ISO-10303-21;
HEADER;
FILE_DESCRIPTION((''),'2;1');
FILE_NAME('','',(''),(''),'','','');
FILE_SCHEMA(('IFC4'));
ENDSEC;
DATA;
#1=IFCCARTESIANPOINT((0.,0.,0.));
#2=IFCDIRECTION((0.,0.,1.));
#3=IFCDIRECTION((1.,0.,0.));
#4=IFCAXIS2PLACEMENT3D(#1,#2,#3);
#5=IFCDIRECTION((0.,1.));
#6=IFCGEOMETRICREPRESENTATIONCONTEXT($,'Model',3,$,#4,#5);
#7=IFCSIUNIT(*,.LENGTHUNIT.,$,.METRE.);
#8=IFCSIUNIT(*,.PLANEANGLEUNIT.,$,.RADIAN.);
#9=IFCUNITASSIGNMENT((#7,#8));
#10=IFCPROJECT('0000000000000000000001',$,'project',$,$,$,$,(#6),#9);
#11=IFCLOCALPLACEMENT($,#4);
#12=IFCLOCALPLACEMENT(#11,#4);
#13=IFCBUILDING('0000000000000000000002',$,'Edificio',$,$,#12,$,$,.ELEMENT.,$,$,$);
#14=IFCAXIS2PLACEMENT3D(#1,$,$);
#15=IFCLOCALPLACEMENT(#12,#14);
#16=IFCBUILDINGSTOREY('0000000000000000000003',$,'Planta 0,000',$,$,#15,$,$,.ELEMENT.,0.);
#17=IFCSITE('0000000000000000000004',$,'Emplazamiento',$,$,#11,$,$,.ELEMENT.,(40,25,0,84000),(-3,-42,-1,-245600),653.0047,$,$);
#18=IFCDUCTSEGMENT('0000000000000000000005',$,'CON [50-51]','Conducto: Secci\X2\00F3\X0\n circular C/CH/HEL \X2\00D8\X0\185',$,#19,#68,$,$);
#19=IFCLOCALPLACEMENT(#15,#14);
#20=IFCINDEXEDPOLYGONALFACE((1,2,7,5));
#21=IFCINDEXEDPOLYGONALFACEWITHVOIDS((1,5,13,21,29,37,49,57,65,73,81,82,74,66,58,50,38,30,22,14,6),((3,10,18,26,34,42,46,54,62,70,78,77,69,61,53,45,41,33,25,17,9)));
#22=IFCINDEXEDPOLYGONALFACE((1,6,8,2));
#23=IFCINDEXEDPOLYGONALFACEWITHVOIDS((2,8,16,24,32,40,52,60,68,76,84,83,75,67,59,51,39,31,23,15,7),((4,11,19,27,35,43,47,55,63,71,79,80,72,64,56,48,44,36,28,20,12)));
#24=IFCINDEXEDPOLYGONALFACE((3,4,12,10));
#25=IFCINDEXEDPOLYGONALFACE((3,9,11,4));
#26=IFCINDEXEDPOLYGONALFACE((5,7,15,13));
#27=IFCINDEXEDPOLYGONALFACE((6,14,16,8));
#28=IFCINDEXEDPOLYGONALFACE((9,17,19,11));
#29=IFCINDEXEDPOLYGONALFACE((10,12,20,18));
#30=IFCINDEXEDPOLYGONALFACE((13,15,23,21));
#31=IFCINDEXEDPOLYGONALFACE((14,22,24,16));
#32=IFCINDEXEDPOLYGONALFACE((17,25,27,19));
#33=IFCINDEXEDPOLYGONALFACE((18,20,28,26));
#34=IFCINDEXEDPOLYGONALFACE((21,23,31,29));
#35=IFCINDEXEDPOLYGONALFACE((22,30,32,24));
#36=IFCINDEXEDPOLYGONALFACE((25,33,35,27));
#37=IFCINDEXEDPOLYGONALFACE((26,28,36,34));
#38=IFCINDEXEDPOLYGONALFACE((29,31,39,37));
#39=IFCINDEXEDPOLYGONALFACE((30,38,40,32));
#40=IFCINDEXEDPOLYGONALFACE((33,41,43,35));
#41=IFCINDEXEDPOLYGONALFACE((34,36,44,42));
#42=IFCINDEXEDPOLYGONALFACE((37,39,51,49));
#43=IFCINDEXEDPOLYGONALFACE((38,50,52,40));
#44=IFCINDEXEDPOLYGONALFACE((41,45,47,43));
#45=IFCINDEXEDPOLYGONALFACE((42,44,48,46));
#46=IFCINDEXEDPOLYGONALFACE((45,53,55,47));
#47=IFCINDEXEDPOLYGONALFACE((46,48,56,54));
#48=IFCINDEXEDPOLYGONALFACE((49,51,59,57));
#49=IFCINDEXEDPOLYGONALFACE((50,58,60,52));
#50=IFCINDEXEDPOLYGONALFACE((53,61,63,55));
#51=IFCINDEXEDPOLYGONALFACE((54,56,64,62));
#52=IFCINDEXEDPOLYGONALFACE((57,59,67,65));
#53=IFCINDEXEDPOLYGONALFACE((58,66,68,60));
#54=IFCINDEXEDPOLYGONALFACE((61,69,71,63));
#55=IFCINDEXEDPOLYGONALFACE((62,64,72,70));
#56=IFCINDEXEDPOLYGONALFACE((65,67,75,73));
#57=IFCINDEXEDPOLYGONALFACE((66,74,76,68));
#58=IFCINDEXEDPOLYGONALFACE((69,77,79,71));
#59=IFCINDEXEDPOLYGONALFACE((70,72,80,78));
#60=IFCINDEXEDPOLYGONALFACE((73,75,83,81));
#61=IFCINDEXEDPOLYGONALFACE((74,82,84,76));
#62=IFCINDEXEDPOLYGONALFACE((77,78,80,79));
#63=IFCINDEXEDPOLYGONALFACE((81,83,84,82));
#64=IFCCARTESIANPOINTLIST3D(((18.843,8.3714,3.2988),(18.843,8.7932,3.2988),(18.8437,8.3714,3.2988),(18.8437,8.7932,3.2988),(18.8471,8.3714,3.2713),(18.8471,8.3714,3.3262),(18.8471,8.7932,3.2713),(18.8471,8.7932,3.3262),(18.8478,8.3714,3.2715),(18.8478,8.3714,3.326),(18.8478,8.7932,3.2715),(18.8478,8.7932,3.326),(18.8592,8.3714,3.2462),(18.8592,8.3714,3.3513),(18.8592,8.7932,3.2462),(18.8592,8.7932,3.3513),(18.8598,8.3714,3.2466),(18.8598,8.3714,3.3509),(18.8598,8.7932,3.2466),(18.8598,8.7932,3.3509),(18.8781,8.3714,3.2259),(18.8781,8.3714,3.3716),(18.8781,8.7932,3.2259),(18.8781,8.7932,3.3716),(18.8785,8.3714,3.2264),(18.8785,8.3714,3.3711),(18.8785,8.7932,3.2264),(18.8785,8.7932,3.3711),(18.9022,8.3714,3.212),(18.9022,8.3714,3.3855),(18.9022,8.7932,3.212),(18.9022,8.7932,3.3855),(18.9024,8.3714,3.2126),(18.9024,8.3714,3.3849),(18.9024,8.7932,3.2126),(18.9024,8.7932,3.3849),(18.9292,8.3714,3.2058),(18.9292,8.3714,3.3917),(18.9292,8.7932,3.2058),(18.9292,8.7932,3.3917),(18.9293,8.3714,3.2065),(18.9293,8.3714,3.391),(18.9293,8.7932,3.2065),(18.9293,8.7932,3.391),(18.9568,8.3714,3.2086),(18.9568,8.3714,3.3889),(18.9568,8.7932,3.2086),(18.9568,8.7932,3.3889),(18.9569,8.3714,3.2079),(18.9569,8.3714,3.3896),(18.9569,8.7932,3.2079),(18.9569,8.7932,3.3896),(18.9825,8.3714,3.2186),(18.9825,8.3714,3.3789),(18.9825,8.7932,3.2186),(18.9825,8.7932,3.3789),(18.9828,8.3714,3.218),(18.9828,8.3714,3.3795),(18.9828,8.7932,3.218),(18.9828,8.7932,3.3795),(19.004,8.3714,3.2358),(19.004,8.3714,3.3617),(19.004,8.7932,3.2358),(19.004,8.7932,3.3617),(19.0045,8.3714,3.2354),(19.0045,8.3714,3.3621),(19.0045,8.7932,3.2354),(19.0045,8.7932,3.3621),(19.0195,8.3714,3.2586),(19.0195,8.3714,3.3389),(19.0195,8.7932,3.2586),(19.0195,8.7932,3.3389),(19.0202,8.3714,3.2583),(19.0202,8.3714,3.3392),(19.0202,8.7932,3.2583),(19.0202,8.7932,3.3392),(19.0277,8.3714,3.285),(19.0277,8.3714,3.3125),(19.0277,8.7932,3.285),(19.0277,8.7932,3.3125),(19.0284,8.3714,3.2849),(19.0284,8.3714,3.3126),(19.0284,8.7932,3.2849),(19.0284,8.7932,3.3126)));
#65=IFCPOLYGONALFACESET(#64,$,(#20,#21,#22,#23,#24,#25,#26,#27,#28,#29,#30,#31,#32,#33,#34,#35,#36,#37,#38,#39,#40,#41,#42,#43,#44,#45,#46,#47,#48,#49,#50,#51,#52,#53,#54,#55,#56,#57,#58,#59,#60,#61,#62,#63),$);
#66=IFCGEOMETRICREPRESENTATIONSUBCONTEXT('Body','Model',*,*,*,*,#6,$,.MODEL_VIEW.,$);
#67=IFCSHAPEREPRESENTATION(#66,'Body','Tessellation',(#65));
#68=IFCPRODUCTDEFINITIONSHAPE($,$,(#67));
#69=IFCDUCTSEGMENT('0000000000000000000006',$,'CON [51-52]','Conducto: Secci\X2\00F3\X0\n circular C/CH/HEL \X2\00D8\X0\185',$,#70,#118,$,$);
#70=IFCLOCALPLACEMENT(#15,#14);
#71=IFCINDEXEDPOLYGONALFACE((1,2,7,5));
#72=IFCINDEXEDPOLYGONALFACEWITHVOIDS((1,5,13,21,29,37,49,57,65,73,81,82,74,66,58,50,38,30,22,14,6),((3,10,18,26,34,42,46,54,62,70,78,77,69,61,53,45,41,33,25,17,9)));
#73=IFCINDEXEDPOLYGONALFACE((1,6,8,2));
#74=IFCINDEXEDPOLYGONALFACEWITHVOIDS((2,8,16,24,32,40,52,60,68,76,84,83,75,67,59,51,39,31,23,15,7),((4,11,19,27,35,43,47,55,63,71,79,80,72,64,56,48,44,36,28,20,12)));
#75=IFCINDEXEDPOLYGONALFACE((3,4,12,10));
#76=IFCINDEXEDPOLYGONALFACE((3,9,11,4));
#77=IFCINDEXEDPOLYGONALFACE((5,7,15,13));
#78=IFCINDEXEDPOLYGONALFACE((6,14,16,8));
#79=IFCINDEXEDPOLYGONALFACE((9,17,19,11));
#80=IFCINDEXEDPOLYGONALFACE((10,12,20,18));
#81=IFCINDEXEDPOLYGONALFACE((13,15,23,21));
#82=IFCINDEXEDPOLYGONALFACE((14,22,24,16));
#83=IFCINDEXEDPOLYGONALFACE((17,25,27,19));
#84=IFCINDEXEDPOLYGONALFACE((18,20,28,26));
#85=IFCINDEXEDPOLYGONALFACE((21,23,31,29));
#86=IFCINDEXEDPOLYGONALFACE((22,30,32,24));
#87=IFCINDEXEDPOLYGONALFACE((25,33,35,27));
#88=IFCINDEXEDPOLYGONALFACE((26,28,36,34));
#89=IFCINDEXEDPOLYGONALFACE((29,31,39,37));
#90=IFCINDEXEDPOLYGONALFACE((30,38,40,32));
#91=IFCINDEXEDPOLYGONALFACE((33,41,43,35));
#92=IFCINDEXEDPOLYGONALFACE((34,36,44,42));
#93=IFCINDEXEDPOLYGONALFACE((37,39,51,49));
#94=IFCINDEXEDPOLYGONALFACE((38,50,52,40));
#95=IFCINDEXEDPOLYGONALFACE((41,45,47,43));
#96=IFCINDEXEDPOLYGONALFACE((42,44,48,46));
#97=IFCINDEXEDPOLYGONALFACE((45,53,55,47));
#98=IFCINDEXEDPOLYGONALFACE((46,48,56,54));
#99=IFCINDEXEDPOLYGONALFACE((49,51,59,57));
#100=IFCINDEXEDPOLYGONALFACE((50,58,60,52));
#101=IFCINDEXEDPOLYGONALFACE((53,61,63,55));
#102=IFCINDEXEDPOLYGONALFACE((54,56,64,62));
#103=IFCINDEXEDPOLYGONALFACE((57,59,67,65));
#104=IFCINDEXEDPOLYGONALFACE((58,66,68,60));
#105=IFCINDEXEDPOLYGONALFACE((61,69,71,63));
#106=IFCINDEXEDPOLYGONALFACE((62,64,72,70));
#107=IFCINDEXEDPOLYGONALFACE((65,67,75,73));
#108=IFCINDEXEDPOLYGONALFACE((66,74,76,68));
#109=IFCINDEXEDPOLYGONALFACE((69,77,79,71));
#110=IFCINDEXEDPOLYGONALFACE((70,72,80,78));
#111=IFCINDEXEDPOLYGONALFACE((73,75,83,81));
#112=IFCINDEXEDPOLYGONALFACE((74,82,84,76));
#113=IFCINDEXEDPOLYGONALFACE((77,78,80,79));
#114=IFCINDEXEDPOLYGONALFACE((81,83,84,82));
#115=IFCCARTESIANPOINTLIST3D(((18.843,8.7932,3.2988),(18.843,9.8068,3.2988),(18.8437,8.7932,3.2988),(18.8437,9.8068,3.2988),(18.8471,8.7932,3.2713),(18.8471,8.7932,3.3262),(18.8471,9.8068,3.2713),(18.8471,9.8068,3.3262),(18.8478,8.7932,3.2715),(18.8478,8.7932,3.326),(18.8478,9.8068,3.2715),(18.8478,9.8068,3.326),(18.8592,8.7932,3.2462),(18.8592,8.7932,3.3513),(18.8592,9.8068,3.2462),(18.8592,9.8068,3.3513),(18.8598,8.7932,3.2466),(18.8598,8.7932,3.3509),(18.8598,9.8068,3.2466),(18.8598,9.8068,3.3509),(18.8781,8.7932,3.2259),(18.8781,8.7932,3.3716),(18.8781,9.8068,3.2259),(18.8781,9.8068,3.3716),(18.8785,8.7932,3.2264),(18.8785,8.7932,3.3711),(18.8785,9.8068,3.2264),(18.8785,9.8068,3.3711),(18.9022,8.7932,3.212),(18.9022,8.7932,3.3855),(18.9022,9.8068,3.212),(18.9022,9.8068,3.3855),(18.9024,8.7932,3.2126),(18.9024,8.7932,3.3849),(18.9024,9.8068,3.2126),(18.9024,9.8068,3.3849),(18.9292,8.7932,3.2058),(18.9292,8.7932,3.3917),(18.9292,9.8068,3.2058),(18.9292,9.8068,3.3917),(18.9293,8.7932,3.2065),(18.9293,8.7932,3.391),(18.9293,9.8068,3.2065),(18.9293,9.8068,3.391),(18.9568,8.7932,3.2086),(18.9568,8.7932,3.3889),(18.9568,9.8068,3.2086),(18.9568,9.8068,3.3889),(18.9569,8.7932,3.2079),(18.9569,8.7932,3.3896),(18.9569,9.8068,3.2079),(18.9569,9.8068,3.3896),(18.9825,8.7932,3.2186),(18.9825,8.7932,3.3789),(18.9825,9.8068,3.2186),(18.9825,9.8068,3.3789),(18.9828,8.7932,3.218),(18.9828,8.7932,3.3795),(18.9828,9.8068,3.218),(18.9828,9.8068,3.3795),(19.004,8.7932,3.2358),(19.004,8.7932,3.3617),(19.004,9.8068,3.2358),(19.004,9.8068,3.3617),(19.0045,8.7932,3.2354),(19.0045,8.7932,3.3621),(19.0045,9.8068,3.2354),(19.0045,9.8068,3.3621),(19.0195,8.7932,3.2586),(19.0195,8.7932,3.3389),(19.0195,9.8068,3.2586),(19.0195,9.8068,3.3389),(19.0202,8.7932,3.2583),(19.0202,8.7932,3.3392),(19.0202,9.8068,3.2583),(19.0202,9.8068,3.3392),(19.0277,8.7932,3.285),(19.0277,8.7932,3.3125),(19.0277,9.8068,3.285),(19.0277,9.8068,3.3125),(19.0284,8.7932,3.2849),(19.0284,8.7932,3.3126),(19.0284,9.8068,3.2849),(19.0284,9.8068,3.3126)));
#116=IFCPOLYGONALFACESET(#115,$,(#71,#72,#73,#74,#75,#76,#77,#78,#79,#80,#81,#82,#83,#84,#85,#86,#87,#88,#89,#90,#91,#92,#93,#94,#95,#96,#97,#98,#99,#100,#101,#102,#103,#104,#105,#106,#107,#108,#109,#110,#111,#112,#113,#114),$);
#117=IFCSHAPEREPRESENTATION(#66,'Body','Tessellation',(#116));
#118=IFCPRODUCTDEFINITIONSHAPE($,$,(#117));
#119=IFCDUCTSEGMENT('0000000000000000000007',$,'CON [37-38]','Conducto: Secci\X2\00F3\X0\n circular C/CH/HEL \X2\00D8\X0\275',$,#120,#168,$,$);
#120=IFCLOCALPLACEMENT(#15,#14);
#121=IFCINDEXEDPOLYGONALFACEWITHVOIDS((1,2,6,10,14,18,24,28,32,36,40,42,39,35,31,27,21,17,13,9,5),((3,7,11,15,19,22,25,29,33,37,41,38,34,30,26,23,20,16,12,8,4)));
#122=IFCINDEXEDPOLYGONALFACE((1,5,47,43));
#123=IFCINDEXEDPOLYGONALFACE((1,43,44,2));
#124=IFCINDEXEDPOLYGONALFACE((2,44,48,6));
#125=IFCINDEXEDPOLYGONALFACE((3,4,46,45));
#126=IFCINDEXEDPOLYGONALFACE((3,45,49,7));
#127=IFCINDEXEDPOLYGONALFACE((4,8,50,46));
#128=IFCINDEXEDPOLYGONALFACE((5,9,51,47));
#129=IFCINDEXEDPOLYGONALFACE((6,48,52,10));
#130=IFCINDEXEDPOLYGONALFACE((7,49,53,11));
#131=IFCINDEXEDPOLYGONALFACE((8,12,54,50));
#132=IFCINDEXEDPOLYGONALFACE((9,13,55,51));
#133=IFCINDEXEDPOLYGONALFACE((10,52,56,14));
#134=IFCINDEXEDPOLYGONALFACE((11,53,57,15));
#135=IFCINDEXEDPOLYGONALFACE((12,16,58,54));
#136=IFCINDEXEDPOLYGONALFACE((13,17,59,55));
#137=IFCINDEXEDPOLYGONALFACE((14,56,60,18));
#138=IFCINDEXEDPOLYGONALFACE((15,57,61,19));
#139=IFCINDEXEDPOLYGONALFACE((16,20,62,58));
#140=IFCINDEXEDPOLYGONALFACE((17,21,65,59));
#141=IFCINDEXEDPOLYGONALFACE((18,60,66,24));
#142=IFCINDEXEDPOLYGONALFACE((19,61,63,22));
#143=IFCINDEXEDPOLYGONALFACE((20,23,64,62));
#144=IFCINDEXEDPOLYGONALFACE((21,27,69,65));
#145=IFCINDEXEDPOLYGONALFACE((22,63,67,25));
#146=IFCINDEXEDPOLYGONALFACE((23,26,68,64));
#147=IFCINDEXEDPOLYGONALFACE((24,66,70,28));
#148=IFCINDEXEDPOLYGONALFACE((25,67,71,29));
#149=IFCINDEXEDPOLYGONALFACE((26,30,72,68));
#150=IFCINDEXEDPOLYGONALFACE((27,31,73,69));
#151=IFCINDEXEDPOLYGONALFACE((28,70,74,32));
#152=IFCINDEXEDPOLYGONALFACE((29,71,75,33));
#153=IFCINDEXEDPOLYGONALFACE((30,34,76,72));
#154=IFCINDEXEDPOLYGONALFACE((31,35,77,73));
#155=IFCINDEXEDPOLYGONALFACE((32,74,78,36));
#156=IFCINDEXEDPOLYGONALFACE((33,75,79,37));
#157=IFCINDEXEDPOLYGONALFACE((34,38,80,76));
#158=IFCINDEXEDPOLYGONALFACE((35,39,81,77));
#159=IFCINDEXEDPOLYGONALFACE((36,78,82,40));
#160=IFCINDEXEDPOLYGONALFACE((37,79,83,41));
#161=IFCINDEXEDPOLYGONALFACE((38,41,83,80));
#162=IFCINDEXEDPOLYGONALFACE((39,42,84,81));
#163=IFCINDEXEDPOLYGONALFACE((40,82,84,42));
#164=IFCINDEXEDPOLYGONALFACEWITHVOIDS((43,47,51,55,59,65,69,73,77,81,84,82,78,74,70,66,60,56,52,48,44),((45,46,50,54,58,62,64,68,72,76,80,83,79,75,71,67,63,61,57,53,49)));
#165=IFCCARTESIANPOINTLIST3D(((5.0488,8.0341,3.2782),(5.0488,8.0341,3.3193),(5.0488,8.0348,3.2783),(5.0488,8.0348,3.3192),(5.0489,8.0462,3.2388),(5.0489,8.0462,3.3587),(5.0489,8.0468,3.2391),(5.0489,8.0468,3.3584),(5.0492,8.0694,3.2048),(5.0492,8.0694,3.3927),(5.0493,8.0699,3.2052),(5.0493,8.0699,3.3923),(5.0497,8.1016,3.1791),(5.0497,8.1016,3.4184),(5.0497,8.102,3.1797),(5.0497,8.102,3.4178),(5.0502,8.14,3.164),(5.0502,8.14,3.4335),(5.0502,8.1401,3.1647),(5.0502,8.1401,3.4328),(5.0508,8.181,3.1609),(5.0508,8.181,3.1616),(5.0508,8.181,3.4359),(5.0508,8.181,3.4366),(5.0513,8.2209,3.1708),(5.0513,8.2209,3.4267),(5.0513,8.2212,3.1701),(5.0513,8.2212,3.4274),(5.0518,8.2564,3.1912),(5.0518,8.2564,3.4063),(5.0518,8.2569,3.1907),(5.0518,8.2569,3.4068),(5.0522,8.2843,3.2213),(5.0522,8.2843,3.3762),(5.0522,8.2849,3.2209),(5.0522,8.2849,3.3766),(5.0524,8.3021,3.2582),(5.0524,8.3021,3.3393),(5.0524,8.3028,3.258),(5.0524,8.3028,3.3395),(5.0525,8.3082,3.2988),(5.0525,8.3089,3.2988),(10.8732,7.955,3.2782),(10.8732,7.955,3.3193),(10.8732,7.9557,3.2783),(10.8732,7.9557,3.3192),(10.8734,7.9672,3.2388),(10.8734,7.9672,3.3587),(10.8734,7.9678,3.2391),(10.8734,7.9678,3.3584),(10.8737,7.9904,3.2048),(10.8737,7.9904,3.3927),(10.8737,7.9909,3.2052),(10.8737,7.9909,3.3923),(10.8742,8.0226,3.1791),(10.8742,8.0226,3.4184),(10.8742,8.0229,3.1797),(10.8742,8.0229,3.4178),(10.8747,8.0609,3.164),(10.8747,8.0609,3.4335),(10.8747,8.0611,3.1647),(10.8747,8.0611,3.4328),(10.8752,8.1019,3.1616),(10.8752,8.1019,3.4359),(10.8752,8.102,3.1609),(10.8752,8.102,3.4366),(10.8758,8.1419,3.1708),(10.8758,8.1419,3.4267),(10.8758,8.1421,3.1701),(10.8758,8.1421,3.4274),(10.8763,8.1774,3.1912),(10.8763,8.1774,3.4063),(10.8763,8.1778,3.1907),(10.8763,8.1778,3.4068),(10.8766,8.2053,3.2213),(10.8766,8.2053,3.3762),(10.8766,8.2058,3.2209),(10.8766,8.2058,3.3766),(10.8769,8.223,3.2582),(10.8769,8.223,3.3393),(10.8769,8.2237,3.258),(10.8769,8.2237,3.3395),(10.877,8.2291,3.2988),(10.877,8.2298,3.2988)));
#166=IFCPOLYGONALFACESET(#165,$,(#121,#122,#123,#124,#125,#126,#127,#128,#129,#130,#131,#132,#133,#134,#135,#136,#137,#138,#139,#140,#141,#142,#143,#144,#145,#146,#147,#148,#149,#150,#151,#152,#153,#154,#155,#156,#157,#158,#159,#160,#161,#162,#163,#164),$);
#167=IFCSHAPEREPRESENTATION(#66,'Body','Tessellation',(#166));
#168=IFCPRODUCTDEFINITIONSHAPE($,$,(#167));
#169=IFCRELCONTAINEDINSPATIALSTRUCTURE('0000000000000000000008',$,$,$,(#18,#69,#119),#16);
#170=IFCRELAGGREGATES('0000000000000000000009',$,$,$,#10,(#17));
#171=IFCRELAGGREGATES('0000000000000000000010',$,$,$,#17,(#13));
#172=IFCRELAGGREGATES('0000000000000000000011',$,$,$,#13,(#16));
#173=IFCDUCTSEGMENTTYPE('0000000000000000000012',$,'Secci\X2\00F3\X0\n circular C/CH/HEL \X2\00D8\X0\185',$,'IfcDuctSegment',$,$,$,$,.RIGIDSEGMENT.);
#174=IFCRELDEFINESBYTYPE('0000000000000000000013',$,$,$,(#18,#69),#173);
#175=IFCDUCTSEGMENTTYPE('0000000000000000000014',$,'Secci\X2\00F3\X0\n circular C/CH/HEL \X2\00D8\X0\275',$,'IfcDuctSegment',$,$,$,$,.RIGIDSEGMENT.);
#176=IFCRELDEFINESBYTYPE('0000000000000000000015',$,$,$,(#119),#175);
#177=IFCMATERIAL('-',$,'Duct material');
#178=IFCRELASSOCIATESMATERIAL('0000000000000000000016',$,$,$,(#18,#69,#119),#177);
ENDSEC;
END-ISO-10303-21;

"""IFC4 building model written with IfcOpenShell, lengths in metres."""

from ifc_helpers import new_model, si_unit, direction, frame, origin, origin_with_axes, origin_2d_with_axis, place, context, subcontext, project, spatial, hollow_circle, extrude, material, type_object, element, save


model = new_model("IFC4")

# Units and contexts
model_context = context("Model", 3, world=origin_with_axes(), true_north=direction((0.0, 1.0)))
body_context = subcontext(model_context, "Body", "Model", "MODEL_VIEW")
ifc_project = project(units=[si_unit("LENGTHUNIT", "METRE"), si_unit("PLANEANGLEUNIT", "RADIAN")], contexts=[model_context])

# Site, building, storey
site_placement = place(None, origin_with_axes())
site = spatial("IfcSite", under=ifc_project, at=site_placement, Name="Emplazamiento", CompositionType="ELEMENT", RefLatitude=(40, 25, 0, 84000), RefLongitude=(-3, -42, -1, -245600), RefElevation=653.0047)
building_placement = place(site_placement, origin_with_axes())
building = spatial("IfcBuilding", under=site, at=building_placement, Name="Edificio", CompositionType="ELEMENT")
storey_placement = place(building_placement, origin())
storey = spatial("IfcBuildingStorey", under=building, at=storey_placement, Name="Planta 0,000", CompositionType="ELEMENT", Elevation=0.0)

# Shared definitions
ifc_material_1 = material(Name="-", Category="Duct material")

# Duct segments
duct_segment_type_1 = type_object("IfcDuctSegmentType", Name="Sección circular C/CH/HEL Ø185", ApplicableOccurrence="IfcDuctSegment", PredefinedType="RIGIDSEGMENT")
duct_segment_1_placement = place(storey_placement, origin_with_axes())
element("IfcDuctSegment", 1, at=duct_segment_1_placement, inside=storey, type_object=duct_segment_type_1, material=ifc_material_1, Name="CON [50-51]", Description="Conducto: Sección circular C/CH/HEL Ø185", context=body_context, shape_type="SweptSolid", body=[
    extrude(hollow_circle(Radius=0.0932, WallThickness=0.0007, at=origin_2d_with_axis()), frame((18.9362, 8.3714, 3.2988), z_axis=(0.0, 1.0, 0.0), x_axis=(-1.0, 0.0, 0.0)), (0.0, 0.0, 1.0), 0.4218),
])
duct_segment_2_placement = place(storey_placement, origin_with_axes())
element("IfcDuctSegment", 2, at=duct_segment_2_placement, inside=storey, type_object=duct_segment_type_1, material=ifc_material_1, Name="CON [51-52]", Description="Conducto: Sección circular C/CH/HEL Ø185", context=body_context, shape_type="SweptSolid", body=[
    extrude(hollow_circle(Radius=0.0932, WallThickness=0.0007, at=origin_2d_with_axis()), frame((18.9362, 8.7932, 3.2988), z_axis=(0.0, 1.0, 0.0), x_axis=(-1.0, 0.0, 0.0)), (0.0, 0.0, 1.0), 1.0136),
])
duct_segment_type_2 = type_object("IfcDuctSegmentType", Name="Sección circular C/CH/HEL Ø275", ApplicableOccurrence="IfcDuctSegment", PredefinedType="RIGIDSEGMENT")
duct_segment_3_placement = place(storey_placement, origin_with_axes())
element("IfcDuctSegment", 3, at=duct_segment_3_placement, inside=storey, type_object=duct_segment_type_2, material=ifc_material_1, Name="CON [37-38]", Description="Conducto: Sección circular C/CH/HEL Ø275", context=body_context, shape_type="SweptSolid", body=[
    extrude(hollow_circle(Radius=0.1382, WallThickness=0.0007, at=origin_2d_with_axis()), frame((5.0506, 8.1707, 3.2988), z_axis=(0.999908, -0.01357, 0.0), x_axis=(0.01357, 0.999908, 0.0)), (0.0, 0.0, 1.0), 5.825),
])

save(model, "model.ifc")
